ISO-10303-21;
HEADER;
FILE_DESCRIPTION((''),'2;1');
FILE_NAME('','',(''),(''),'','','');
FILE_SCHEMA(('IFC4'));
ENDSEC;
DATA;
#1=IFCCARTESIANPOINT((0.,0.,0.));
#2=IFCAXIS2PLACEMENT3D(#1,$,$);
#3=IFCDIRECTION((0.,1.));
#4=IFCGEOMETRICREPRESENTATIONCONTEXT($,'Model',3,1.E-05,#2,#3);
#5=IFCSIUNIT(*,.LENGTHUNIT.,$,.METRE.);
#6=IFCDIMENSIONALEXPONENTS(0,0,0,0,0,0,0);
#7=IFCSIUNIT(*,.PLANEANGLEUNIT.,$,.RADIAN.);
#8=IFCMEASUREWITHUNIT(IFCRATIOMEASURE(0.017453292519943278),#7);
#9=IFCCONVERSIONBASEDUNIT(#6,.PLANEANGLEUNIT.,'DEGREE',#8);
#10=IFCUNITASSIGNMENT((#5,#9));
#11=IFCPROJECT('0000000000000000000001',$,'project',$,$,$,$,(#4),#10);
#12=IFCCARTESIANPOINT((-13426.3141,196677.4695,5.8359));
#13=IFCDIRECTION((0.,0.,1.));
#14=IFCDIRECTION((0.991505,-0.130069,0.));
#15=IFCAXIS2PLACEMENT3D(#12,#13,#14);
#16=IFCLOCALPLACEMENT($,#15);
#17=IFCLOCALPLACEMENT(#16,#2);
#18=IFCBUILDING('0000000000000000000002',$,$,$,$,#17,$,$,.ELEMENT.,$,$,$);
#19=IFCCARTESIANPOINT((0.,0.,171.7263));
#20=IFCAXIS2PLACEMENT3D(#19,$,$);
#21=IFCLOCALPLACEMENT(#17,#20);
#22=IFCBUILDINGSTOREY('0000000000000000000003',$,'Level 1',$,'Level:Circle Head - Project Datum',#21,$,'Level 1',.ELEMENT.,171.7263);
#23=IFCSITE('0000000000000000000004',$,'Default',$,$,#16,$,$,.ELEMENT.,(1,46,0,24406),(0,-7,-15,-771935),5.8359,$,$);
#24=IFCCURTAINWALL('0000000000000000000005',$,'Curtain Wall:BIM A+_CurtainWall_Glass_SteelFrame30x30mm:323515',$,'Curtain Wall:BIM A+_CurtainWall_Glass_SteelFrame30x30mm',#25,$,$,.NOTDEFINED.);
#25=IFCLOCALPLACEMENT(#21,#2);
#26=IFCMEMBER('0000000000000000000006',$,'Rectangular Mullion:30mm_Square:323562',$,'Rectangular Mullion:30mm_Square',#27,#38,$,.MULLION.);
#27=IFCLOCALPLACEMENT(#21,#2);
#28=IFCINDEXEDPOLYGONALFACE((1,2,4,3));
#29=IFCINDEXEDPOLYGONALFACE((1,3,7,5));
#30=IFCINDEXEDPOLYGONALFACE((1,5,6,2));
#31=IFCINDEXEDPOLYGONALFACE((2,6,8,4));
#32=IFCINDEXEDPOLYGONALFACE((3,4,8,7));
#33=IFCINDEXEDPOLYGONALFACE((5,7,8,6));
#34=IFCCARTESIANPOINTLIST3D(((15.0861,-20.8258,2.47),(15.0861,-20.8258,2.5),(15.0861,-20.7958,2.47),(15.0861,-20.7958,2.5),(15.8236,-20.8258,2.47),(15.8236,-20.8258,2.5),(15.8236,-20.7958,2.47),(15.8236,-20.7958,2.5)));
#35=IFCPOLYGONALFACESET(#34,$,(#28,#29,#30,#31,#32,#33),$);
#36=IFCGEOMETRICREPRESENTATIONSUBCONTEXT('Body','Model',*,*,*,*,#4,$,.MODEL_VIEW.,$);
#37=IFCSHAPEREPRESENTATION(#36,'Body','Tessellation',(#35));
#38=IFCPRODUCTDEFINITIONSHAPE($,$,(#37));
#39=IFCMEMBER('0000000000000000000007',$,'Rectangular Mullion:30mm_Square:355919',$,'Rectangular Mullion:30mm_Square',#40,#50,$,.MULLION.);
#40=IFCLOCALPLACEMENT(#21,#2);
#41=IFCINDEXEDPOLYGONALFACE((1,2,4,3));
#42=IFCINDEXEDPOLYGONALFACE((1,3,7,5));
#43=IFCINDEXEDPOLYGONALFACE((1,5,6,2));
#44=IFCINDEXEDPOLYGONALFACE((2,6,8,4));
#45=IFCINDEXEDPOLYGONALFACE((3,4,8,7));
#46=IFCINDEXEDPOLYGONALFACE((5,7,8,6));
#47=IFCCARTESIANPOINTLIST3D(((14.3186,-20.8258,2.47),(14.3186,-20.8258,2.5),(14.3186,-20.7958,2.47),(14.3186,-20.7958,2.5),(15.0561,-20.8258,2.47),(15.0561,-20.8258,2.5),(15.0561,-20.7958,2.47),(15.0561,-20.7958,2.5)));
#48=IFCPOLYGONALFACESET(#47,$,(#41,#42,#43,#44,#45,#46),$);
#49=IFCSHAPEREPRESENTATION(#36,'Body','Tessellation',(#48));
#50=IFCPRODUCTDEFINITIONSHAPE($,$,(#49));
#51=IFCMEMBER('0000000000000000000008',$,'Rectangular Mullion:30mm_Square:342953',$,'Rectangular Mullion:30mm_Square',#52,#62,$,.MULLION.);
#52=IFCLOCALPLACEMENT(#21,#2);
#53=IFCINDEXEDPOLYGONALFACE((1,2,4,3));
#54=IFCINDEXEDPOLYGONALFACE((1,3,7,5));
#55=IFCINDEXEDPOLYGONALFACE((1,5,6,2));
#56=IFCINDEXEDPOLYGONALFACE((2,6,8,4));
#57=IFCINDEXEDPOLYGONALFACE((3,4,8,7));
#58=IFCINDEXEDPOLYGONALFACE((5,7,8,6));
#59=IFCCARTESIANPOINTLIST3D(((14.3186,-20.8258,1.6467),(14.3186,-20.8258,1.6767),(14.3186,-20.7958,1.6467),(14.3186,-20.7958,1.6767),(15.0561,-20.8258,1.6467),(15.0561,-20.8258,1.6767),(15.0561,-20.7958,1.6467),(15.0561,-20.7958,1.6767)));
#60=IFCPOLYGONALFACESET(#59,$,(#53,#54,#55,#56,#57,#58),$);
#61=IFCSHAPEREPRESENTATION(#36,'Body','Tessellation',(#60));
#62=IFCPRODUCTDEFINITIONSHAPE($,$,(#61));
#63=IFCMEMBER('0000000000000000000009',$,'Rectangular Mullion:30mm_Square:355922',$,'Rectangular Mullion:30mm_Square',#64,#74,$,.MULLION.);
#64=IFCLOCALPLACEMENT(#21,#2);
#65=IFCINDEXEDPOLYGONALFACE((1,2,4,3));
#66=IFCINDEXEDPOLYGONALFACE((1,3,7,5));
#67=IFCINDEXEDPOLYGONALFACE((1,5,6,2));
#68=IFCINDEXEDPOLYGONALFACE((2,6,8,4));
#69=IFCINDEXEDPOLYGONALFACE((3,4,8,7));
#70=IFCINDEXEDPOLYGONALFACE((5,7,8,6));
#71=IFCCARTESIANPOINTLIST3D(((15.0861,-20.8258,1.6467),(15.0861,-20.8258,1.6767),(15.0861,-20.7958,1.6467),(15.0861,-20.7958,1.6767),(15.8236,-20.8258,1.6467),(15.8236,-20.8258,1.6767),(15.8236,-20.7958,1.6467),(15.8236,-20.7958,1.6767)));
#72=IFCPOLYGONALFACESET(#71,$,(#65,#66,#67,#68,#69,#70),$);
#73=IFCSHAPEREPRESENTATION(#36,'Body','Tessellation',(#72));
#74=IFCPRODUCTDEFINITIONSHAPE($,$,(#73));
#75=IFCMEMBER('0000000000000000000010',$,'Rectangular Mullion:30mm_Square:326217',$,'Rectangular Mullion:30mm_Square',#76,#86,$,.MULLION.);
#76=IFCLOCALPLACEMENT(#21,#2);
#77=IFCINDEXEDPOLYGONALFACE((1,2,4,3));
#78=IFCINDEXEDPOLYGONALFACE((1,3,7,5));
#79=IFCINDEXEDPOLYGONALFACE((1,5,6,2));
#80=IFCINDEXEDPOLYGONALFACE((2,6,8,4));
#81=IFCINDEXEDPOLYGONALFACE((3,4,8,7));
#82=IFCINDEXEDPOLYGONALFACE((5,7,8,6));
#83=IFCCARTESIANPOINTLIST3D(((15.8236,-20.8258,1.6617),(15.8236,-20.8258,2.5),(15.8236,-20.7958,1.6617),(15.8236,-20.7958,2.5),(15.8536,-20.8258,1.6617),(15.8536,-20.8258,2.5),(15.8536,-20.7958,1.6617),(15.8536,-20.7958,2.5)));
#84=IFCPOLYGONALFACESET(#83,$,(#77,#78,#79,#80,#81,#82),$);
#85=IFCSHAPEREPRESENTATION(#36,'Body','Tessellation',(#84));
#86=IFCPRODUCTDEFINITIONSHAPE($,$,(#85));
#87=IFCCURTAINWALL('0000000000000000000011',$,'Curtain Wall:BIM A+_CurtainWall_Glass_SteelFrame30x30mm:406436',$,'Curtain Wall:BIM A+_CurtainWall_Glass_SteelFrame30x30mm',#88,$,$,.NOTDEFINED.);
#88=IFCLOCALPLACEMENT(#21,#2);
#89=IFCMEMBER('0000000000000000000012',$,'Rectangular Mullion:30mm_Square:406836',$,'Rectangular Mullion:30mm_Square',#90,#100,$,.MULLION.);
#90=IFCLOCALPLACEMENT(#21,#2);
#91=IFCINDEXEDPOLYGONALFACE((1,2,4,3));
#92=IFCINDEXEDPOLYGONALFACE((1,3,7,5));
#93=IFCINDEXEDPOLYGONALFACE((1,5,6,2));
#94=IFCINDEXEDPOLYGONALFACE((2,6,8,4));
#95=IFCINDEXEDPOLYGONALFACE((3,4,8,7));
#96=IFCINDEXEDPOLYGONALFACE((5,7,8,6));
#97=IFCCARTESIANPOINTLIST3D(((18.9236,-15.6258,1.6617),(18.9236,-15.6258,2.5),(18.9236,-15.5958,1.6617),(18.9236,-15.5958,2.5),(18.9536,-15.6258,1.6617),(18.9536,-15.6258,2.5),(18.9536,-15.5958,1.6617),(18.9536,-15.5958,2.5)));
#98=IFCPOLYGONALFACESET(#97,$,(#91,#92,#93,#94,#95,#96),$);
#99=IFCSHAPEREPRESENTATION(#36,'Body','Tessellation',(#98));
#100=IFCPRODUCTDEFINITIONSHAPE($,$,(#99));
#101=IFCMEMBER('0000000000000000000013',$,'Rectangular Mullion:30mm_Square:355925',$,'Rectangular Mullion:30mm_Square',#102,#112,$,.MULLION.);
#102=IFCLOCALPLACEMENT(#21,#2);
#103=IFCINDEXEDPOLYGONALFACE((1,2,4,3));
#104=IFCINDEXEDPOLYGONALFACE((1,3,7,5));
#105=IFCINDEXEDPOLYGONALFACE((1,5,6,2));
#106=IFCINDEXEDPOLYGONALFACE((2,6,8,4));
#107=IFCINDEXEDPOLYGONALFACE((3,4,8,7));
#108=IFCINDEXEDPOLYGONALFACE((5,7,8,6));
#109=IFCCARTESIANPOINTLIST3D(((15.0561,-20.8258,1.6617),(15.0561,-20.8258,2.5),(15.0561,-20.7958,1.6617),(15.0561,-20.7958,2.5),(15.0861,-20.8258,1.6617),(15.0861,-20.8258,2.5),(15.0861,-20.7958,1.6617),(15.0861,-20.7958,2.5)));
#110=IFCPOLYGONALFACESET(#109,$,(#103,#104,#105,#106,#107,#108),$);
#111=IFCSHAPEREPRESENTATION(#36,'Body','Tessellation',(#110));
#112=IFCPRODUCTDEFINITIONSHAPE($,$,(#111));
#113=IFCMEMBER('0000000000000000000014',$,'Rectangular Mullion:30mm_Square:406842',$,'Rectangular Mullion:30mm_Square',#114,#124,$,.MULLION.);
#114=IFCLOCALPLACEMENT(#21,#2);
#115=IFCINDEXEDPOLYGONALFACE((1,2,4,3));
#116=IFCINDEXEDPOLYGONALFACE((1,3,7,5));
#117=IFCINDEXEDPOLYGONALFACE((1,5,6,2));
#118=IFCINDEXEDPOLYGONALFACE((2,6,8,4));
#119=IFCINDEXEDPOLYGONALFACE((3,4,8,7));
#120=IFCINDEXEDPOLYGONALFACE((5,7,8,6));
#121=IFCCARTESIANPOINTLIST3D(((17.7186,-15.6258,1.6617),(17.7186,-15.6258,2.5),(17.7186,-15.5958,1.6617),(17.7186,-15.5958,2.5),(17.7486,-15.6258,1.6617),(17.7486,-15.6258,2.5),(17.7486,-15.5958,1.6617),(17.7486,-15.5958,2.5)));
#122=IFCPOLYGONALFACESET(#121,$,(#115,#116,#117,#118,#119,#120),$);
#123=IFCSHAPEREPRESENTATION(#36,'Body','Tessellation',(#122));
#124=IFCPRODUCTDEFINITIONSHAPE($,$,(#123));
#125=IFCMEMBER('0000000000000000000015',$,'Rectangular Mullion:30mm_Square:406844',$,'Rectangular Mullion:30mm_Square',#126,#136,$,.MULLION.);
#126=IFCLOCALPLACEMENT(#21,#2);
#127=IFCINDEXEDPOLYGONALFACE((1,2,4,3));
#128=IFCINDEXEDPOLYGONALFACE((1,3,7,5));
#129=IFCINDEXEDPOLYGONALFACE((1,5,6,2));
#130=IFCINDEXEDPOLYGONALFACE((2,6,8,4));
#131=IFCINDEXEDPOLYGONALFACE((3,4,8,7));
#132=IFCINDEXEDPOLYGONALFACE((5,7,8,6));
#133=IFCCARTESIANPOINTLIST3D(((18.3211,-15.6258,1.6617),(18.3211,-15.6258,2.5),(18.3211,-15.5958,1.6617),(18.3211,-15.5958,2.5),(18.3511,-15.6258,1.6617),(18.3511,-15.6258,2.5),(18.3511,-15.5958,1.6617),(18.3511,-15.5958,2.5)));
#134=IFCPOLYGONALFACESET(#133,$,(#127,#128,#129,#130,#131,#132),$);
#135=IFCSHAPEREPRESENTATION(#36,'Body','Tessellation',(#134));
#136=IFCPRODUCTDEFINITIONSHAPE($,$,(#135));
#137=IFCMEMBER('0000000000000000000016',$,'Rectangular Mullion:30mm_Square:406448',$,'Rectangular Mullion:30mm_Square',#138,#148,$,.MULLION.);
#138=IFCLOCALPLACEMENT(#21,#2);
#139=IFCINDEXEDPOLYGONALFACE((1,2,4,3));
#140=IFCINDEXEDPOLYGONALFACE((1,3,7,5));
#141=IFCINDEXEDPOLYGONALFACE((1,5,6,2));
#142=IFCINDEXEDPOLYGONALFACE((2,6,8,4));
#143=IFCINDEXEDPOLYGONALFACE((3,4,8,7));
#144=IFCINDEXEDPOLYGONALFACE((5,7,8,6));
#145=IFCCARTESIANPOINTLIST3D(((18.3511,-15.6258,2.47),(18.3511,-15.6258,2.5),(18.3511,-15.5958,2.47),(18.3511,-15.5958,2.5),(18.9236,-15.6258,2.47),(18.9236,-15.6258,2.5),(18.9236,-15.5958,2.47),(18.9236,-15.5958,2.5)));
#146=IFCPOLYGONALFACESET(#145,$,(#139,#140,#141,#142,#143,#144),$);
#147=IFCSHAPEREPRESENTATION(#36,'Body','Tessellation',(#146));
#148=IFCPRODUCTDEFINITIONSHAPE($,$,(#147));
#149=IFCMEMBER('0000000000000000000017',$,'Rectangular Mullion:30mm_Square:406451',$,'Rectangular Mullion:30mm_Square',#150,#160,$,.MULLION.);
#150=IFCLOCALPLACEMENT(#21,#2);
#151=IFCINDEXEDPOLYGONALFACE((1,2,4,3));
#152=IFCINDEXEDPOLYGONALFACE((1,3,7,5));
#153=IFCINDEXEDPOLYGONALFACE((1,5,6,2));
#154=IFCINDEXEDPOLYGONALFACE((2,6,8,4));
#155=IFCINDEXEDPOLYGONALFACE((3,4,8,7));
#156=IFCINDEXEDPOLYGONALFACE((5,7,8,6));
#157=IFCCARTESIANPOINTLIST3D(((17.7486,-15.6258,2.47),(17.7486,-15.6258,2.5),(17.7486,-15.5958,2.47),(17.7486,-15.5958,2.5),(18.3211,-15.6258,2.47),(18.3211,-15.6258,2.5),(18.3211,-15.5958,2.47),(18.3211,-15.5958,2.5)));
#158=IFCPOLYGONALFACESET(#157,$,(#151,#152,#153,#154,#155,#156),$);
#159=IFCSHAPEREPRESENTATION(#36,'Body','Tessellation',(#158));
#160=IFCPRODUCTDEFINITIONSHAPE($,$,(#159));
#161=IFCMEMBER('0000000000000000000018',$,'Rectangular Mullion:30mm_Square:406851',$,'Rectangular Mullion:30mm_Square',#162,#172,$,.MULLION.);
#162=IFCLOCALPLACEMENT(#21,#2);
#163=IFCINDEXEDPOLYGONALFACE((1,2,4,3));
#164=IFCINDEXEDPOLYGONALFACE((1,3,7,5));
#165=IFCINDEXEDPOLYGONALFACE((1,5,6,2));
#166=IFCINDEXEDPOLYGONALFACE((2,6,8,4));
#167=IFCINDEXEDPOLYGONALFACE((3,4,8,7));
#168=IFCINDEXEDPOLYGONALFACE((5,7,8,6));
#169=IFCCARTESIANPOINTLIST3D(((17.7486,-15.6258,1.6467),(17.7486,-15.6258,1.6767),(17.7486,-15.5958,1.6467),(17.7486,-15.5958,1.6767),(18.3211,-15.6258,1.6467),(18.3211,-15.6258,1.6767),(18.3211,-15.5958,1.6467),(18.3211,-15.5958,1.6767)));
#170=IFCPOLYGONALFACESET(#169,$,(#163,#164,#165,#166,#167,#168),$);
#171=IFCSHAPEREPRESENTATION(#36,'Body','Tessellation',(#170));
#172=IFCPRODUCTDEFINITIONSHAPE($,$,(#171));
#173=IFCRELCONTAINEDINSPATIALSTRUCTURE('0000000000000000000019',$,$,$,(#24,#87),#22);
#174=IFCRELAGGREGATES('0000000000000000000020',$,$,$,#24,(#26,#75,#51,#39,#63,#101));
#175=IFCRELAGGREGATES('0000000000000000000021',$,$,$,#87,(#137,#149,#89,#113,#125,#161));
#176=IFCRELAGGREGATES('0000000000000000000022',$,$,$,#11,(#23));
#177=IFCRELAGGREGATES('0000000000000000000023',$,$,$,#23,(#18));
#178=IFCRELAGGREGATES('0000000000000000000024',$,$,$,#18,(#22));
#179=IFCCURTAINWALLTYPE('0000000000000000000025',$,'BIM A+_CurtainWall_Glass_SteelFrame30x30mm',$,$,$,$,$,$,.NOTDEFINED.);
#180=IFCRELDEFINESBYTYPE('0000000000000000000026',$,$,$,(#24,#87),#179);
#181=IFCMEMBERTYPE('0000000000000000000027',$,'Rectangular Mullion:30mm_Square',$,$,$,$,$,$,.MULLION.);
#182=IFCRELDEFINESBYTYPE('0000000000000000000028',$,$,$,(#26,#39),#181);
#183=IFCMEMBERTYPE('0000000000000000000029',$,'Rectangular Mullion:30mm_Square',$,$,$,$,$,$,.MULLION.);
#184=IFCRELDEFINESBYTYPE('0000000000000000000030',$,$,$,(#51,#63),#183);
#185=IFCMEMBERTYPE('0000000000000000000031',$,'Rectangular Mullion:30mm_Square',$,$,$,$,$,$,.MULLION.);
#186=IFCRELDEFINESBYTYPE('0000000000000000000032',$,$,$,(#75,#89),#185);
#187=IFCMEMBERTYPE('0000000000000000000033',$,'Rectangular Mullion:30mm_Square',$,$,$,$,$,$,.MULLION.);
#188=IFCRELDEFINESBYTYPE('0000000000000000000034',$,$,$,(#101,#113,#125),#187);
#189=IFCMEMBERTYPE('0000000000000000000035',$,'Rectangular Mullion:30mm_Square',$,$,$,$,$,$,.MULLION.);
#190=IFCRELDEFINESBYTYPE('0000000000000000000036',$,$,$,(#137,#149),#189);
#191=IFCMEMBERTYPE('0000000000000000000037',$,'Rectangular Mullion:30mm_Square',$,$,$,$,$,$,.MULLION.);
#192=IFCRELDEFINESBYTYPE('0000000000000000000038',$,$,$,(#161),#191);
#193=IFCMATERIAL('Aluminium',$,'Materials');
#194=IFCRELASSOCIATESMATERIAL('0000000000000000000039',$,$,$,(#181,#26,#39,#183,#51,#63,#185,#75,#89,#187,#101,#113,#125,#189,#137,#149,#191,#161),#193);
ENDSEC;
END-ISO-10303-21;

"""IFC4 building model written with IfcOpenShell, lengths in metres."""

from ifc_helpers import new_model, entity, si_unit, converted_unit, direction, frame, origin, place, context, subcontext, project, spatial, indexed_curve, outline, extrude, source, transform, mapped, material, type_object, type_shapes, element, aggregate, save


model = new_model("IFC4")

# Units and contexts
model_context = context("Model", 3, precision=1e-05, world=origin(), true_north=direction((0.0, 1.0)))
body_context = subcontext(model_context, "Body", "Model", "MODEL_VIEW")
ifc_project = project(units=[si_unit("LENGTHUNIT", "METRE"), converted_unit("PLANEANGLEUNIT", "DEGREE", entity("IfcRatioMeasure", 0.017453292519943278), si_unit("PLANEANGLEUNIT", "RADIAN"), dimensions=[0, 0, 0, 0, 0, 0, 0])], contexts=[model_context])

# Site, building, storey
site_placement = place(None, frame((-13426.3141, 196677.4695, 5.8359), z_axis=(0.0, 0.0, 1.0), x_axis=(0.991505, -0.130069, 0.0)))
site = spatial("IfcSite", under=ifc_project, at=site_placement, Name="Default", CompositionType="ELEMENT", RefLatitude=(1, 46, 0, 24406), RefLongitude=(0, -7, -15, -771935), RefElevation=5.8359)
building_placement = place(site_placement, origin())
building = spatial("IfcBuilding", under=site, at=building_placement, CompositionType="ELEMENT")
storey_placement = place(building_placement, frame((0.0, 0.0, 171.7263)))
storey = spatial("IfcBuildingStorey", under=building, at=storey_placement, Name="Level 1", ObjectType="Level:Circle Head - Project Datum", LongName="Level 1", CompositionType="ELEMENT", Elevation=171.7263)

# Curtain wall, members
curtain_wall_type_1 = type_object("IfcCurtainWallType", Name="BIM A+_CurtainWall_Glass_SteelFrame30x30mm", PredefinedType="NOTDEFINED")
curtain_wall_1_placement = place(storey_placement, frame((0.0, 0.0, -171.7263)))
curtain_wall_1 = element("IfcCurtainWall", 1, at=curtain_wall_1_placement, inside=storey, type_object=curtain_wall_type_1, Name="Curtain Wall:BIM A+_CurtainWall_Glass_SteelFrame30x30mm:323515", ObjectType="Curtain Wall:BIM A+_CurtainWall_Glass_SteelFrame30x30mm", PredefinedType="NOTDEFINED")
ifc_material_1 = material(Name="Aluminium", Category="Materials")
member_type_1 = type_object("IfcMemberType", Name="Rectangular Mullion:30mm_Square", PredefinedType="MULLION", material=ifc_material_1)
shared_shape_1 = source(origin(), body_context, "Body", "SweptSolid", [
    extrude(outline(indexed_curve([(-0.015, -0.015), (0.015, -0.015), (0.015, 0.015), (-0.015, 0.015), (-0.015, -0.015)], self_intersect=False)), frame((-0.015, 0.0, -0.7375), z_axis=(0.0, 0.0, 1.0), x_axis=(0.0, -1.0, 0.0)), (0.0, 0.0, 1.0), 0.7375),
])
type_shapes(member_type_1, [shared_shape_1])
member_1_placement = place(curtain_wall_1_placement, frame((15.8236, -20.8108, 174.2263), z_axis=(1.0, 0.0, 0.0), x_axis=(0.0, 0.0, 1.0)))
member_1 = element("IfcMember", 2, at=member_1_placement, type_object=member_type_1, material=ifc_material_1, Name="Rectangular Mullion:30mm_Square:323562", ObjectType="Rectangular Mullion:30mm_Square", PredefinedType="MULLION", context=body_context, shape_type="MappedRepresentation", body=[
    mapped(shared_shape_1, transform((0.0, 0.0, 0.0), scale=1.0)),
])
member_2_placement = place(curtain_wall_1_placement, frame((15.0561, -20.8108, 174.2263), z_axis=(1.0, 0.0, 0.0), x_axis=(0.0, 0.0, 1.0)))
member_2 = element("IfcMember", 3, at=member_2_placement, type_object=member_type_1, material=ifc_material_1, Name="Rectangular Mullion:30mm_Square:355919", ObjectType="Rectangular Mullion:30mm_Square", PredefinedType="MULLION", context=body_context, shape_type="MappedRepresentation", body=[
    mapped(shared_shape_1, transform((0.0, 0.0, 0.0), scale=1.0)),
])
member_type_2 = type_object("IfcMemberType", Name="Rectangular Mullion:30mm_Square", PredefinedType="MULLION", material=ifc_material_1)
shared_shape_2 = source(origin(), body_context, "Body", "SweptSolid", [
    extrude(outline(indexed_curve([(-0.015, -0.015), (0.015, -0.015), (0.015, 0.015), (-0.015, 0.015), (-0.015, -0.015)], self_intersect=False)), frame((0.0, 0.0, -0.7375), z_axis=(0.0, 0.0, 1.0), x_axis=(0.0, -1.0, 0.0)), (0.0, 0.0, 1.0), 0.7375),
])
type_shapes(member_type_2, [shared_shape_2])
member_3_placement = place(curtain_wall_1_placement, frame((15.0561, -20.8108, 173.3879), z_axis=(1.0, 0.0, 0.0), x_axis=(0.0, 0.0, 1.0)))
member_3 = element("IfcMember", 4, at=member_3_placement, type_object=member_type_2, material=ifc_material_1, Name="Rectangular Mullion:30mm_Square:342953", ObjectType="Rectangular Mullion:30mm_Square", PredefinedType="MULLION", context=body_context, shape_type="MappedRepresentation", body=[
    mapped(shared_shape_2, transform((0.0, 0.0, 0.0), scale=1.0)),
])
member_4_placement = place(curtain_wall_1_placement, frame((15.8236, -20.8108, 173.3879), z_axis=(1.0, 0.0, 0.0), x_axis=(0.0, 0.0, 1.0)))
member_4 = element("IfcMember", 5, at=member_4_placement, type_object=member_type_2, material=ifc_material_1, Name="Rectangular Mullion:30mm_Square:355922", ObjectType="Rectangular Mullion:30mm_Square", PredefinedType="MULLION", context=body_context, shape_type="MappedRepresentation", body=[
    mapped(shared_shape_2, transform((0.0, 0.0, 0.0), scale=1.0)),
])
member_type_3 = type_object("IfcMemberType", Name="Rectangular Mullion:30mm_Square", PredefinedType="MULLION", material=ifc_material_1)
shared_shape_3 = source(origin(), body_context, "Body", "SweptSolid", [
    extrude(outline(indexed_curve([(-0.015, -0.015), (0.015, -0.015), (0.015, 0.015), (-0.015, 0.015), (-0.015, -0.015)], self_intersect=False)), frame((-0.015, 0.0, -0.8383), z_axis=(0.0, 0.0, 1.0), x_axis=(0.0, -1.0, 0.0)), (0.0, 0.0, 1.0), 0.8383),
])
type_shapes(member_type_3, [shared_shape_3])
member_5_placement = place(curtain_wall_1_placement, frame((15.8536, -20.8108, 173.3879), z_axis=(0.0, 0.0, -1.0), x_axis=(1.0, 0.0, 0.0)))
member_5 = element("IfcMember", 6, at=member_5_placement, type_object=member_type_3, material=ifc_material_1, Name="Rectangular Mullion:30mm_Square:326217", ObjectType="Rectangular Mullion:30mm_Square", PredefinedType="MULLION", context=body_context, shape_type="MappedRepresentation", body=[
    mapped(shared_shape_3, transform((0.0, 0.0, 0.0), scale=1.0)),
])

# Curtain wall, member
curtain_wall_2_placement = place(storey_placement, frame((0.0, 0.0, -171.7263)))
curtain_wall_2 = element("IfcCurtainWall", 7, at=curtain_wall_2_placement, inside=storey, type_object=curtain_wall_type_1, Name="Curtain Wall:BIM A+_CurtainWall_Glass_SteelFrame30x30mm:406436", ObjectType="Curtain Wall:BIM A+_CurtainWall_Glass_SteelFrame30x30mm", PredefinedType="NOTDEFINED")
member_6_placement = place(curtain_wall_2_placement, frame((18.9536, -15.6108, 173.3879), z_axis=(0.0, 0.0, -1.0), x_axis=(1.0, 0.0, 0.0)))
member_6 = element("IfcMember", 8, at=member_6_placement, type_object=member_type_3, material=ifc_material_1, Name="Rectangular Mullion:30mm_Square:406836", ObjectType="Rectangular Mullion:30mm_Square", PredefinedType="MULLION", context=body_context, shape_type="MappedRepresentation", body=[
    mapped(shared_shape_3, transform((0.0, 0.0, 0.0), scale=1.0)),
])

# Members
member_type_4 = type_object("IfcMemberType", Name="Rectangular Mullion:30mm_Square", PredefinedType="MULLION", material=ifc_material_1)
shared_shape_4 = source(origin(), body_context, "Body", "SweptSolid", [
    extrude(outline(indexed_curve([(-0.015, -0.015), (0.015, -0.015), (0.015, 0.015), (-0.015, 0.015), (-0.015, -0.015)], self_intersect=False)), frame((0.0, 0.0, -0.8383), z_axis=(0.0, 0.0, 1.0), x_axis=(0.0, -1.0, 0.0)), (0.0, 0.0, 1.0), 0.8383),
])
type_shapes(member_type_4, [shared_shape_4])
member_7_placement = place(curtain_wall_1_placement, frame((15.0711, -20.8108, 173.3879), z_axis=(0.0, 0.0, -1.0), x_axis=(1.0, 0.0, 0.0)))
member_7 = element("IfcMember", 9, at=member_7_placement, type_object=member_type_4, material=ifc_material_1, Name="Rectangular Mullion:30mm_Square:355925", ObjectType="Rectangular Mullion:30mm_Square", PredefinedType="MULLION", context=body_context, shape_type="MappedRepresentation", body=[
    mapped(shared_shape_4, transform((0.0, 0.0, 0.0), scale=1.0)),
])
member_8_placement = place(curtain_wall_2_placement, frame((17.7336, -15.6108, 173.3879), z_axis=(0.0, 0.0, -1.0), x_axis=(1.0, 0.0, 0.0)))
member_8 = element("IfcMember", 10, at=member_8_placement, type_object=member_type_4, material=ifc_material_1, Name="Rectangular Mullion:30mm_Square:406842", ObjectType="Rectangular Mullion:30mm_Square", PredefinedType="MULLION", context=body_context, shape_type="MappedRepresentation", body=[
    mapped(shared_shape_4, transform((0.0, 0.0, 0.0), scale=1.0)),
])
member_9_placement = place(curtain_wall_2_placement, frame((18.3361, -15.6108, 173.3879), z_axis=(0.0, 0.0, -1.0), x_axis=(1.0, 0.0, 0.0)))
member_9 = element("IfcMember", 11, at=member_9_placement, type_object=member_type_4, material=ifc_material_1, Name="Rectangular Mullion:30mm_Square:406844", ObjectType="Rectangular Mullion:30mm_Square", PredefinedType="MULLION", context=body_context, shape_type="MappedRepresentation", body=[
    mapped(shared_shape_4, transform((0.0, 0.0, 0.0), scale=1.0)),
])
member_type_5 = type_object("IfcMemberType", Name="Rectangular Mullion:30mm_Square", PredefinedType="MULLION", material=ifc_material_1)
shared_shape_5 = source(origin(), body_context, "Body", "SweptSolid", [
    extrude(outline(indexed_curve([(-0.015, -0.015), (0.015, -0.015), (0.015, 0.015), (-0.015, 0.015), (-0.015, -0.015)], self_intersect=False)), frame((-0.015, 0.0, -0.5725), z_axis=(0.0, 0.0, 1.0), x_axis=(0.0, -1.0, 0.0)), (0.0, 0.0, 1.0), 0.5725),
])
type_shapes(member_type_5, [shared_shape_5])
member_10_placement = place(curtain_wall_2_placement, frame((18.9236, -15.6108, 174.2263), z_axis=(1.0, 0.0, 0.0), x_axis=(0.0, 0.0, 1.0)))
member_10 = element("IfcMember", 12, at=member_10_placement, type_object=member_type_5, material=ifc_material_1, Name="Rectangular Mullion:30mm_Square:406448", ObjectType="Rectangular Mullion:30mm_Square", PredefinedType="MULLION", context=body_context, shape_type="MappedRepresentation", body=[
    mapped(shared_shape_5, transform((0.0, 0.0, 0.0), scale=1.0)),
])
member_11_placement = place(curtain_wall_2_placement, frame((18.3211, -15.6108, 174.2263), z_axis=(1.0, 0.0, 0.0), x_axis=(0.0, 0.0, 1.0)))
member_11 = element("IfcMember", 13, at=member_11_placement, type_object=member_type_5, material=ifc_material_1, Name="Rectangular Mullion:30mm_Square:406451", ObjectType="Rectangular Mullion:30mm_Square", PredefinedType="MULLION", context=body_context, shape_type="MappedRepresentation", body=[
    mapped(shared_shape_5, transform((0.0, 0.0, 0.0), scale=1.0)),
])
member_type_6 = type_object("IfcMemberType", Name="Rectangular Mullion:30mm_Square", PredefinedType="MULLION", material=ifc_material_1)
shared_shape_6 = source(origin(), body_context, "Body", "SweptSolid", [
    extrude(outline(indexed_curve([(-0.015, -0.015), (0.015, -0.015), (0.015, 0.015), (-0.015, 0.015), (-0.015, -0.015)], self_intersect=False)), frame((0.0, 0.0, -0.5725), z_axis=(0.0, 0.0, 1.0), x_axis=(0.0, -1.0, 0.0)), (0.0, 0.0, 1.0), 0.5725),
])
type_shapes(member_type_6, [shared_shape_6])
member_12_placement = place(curtain_wall_2_placement, frame((18.3211, -15.6108, 173.3879), z_axis=(1.0, 0.0, 0.0), x_axis=(0.0, 0.0, 1.0)))
member_12 = element("IfcMember", 14, at=member_12_placement, type_object=member_type_6, material=ifc_material_1, Name="Rectangular Mullion:30mm_Square:406851", ObjectType="Rectangular Mullion:30mm_Square", PredefinedType="MULLION", context=body_context, shape_type="MappedRepresentation", body=[
    mapped(shared_shape_6, transform((0.0, 0.0, 0.0), scale=1.0)),
])

aggregate(curtain_wall_1, [member_1, member_5, member_3, member_2, member_4, member_7])
aggregate(curtain_wall_2, [member_10, member_11, member_6, member_8, member_9, member_12])

save(model, "model.ifc")
